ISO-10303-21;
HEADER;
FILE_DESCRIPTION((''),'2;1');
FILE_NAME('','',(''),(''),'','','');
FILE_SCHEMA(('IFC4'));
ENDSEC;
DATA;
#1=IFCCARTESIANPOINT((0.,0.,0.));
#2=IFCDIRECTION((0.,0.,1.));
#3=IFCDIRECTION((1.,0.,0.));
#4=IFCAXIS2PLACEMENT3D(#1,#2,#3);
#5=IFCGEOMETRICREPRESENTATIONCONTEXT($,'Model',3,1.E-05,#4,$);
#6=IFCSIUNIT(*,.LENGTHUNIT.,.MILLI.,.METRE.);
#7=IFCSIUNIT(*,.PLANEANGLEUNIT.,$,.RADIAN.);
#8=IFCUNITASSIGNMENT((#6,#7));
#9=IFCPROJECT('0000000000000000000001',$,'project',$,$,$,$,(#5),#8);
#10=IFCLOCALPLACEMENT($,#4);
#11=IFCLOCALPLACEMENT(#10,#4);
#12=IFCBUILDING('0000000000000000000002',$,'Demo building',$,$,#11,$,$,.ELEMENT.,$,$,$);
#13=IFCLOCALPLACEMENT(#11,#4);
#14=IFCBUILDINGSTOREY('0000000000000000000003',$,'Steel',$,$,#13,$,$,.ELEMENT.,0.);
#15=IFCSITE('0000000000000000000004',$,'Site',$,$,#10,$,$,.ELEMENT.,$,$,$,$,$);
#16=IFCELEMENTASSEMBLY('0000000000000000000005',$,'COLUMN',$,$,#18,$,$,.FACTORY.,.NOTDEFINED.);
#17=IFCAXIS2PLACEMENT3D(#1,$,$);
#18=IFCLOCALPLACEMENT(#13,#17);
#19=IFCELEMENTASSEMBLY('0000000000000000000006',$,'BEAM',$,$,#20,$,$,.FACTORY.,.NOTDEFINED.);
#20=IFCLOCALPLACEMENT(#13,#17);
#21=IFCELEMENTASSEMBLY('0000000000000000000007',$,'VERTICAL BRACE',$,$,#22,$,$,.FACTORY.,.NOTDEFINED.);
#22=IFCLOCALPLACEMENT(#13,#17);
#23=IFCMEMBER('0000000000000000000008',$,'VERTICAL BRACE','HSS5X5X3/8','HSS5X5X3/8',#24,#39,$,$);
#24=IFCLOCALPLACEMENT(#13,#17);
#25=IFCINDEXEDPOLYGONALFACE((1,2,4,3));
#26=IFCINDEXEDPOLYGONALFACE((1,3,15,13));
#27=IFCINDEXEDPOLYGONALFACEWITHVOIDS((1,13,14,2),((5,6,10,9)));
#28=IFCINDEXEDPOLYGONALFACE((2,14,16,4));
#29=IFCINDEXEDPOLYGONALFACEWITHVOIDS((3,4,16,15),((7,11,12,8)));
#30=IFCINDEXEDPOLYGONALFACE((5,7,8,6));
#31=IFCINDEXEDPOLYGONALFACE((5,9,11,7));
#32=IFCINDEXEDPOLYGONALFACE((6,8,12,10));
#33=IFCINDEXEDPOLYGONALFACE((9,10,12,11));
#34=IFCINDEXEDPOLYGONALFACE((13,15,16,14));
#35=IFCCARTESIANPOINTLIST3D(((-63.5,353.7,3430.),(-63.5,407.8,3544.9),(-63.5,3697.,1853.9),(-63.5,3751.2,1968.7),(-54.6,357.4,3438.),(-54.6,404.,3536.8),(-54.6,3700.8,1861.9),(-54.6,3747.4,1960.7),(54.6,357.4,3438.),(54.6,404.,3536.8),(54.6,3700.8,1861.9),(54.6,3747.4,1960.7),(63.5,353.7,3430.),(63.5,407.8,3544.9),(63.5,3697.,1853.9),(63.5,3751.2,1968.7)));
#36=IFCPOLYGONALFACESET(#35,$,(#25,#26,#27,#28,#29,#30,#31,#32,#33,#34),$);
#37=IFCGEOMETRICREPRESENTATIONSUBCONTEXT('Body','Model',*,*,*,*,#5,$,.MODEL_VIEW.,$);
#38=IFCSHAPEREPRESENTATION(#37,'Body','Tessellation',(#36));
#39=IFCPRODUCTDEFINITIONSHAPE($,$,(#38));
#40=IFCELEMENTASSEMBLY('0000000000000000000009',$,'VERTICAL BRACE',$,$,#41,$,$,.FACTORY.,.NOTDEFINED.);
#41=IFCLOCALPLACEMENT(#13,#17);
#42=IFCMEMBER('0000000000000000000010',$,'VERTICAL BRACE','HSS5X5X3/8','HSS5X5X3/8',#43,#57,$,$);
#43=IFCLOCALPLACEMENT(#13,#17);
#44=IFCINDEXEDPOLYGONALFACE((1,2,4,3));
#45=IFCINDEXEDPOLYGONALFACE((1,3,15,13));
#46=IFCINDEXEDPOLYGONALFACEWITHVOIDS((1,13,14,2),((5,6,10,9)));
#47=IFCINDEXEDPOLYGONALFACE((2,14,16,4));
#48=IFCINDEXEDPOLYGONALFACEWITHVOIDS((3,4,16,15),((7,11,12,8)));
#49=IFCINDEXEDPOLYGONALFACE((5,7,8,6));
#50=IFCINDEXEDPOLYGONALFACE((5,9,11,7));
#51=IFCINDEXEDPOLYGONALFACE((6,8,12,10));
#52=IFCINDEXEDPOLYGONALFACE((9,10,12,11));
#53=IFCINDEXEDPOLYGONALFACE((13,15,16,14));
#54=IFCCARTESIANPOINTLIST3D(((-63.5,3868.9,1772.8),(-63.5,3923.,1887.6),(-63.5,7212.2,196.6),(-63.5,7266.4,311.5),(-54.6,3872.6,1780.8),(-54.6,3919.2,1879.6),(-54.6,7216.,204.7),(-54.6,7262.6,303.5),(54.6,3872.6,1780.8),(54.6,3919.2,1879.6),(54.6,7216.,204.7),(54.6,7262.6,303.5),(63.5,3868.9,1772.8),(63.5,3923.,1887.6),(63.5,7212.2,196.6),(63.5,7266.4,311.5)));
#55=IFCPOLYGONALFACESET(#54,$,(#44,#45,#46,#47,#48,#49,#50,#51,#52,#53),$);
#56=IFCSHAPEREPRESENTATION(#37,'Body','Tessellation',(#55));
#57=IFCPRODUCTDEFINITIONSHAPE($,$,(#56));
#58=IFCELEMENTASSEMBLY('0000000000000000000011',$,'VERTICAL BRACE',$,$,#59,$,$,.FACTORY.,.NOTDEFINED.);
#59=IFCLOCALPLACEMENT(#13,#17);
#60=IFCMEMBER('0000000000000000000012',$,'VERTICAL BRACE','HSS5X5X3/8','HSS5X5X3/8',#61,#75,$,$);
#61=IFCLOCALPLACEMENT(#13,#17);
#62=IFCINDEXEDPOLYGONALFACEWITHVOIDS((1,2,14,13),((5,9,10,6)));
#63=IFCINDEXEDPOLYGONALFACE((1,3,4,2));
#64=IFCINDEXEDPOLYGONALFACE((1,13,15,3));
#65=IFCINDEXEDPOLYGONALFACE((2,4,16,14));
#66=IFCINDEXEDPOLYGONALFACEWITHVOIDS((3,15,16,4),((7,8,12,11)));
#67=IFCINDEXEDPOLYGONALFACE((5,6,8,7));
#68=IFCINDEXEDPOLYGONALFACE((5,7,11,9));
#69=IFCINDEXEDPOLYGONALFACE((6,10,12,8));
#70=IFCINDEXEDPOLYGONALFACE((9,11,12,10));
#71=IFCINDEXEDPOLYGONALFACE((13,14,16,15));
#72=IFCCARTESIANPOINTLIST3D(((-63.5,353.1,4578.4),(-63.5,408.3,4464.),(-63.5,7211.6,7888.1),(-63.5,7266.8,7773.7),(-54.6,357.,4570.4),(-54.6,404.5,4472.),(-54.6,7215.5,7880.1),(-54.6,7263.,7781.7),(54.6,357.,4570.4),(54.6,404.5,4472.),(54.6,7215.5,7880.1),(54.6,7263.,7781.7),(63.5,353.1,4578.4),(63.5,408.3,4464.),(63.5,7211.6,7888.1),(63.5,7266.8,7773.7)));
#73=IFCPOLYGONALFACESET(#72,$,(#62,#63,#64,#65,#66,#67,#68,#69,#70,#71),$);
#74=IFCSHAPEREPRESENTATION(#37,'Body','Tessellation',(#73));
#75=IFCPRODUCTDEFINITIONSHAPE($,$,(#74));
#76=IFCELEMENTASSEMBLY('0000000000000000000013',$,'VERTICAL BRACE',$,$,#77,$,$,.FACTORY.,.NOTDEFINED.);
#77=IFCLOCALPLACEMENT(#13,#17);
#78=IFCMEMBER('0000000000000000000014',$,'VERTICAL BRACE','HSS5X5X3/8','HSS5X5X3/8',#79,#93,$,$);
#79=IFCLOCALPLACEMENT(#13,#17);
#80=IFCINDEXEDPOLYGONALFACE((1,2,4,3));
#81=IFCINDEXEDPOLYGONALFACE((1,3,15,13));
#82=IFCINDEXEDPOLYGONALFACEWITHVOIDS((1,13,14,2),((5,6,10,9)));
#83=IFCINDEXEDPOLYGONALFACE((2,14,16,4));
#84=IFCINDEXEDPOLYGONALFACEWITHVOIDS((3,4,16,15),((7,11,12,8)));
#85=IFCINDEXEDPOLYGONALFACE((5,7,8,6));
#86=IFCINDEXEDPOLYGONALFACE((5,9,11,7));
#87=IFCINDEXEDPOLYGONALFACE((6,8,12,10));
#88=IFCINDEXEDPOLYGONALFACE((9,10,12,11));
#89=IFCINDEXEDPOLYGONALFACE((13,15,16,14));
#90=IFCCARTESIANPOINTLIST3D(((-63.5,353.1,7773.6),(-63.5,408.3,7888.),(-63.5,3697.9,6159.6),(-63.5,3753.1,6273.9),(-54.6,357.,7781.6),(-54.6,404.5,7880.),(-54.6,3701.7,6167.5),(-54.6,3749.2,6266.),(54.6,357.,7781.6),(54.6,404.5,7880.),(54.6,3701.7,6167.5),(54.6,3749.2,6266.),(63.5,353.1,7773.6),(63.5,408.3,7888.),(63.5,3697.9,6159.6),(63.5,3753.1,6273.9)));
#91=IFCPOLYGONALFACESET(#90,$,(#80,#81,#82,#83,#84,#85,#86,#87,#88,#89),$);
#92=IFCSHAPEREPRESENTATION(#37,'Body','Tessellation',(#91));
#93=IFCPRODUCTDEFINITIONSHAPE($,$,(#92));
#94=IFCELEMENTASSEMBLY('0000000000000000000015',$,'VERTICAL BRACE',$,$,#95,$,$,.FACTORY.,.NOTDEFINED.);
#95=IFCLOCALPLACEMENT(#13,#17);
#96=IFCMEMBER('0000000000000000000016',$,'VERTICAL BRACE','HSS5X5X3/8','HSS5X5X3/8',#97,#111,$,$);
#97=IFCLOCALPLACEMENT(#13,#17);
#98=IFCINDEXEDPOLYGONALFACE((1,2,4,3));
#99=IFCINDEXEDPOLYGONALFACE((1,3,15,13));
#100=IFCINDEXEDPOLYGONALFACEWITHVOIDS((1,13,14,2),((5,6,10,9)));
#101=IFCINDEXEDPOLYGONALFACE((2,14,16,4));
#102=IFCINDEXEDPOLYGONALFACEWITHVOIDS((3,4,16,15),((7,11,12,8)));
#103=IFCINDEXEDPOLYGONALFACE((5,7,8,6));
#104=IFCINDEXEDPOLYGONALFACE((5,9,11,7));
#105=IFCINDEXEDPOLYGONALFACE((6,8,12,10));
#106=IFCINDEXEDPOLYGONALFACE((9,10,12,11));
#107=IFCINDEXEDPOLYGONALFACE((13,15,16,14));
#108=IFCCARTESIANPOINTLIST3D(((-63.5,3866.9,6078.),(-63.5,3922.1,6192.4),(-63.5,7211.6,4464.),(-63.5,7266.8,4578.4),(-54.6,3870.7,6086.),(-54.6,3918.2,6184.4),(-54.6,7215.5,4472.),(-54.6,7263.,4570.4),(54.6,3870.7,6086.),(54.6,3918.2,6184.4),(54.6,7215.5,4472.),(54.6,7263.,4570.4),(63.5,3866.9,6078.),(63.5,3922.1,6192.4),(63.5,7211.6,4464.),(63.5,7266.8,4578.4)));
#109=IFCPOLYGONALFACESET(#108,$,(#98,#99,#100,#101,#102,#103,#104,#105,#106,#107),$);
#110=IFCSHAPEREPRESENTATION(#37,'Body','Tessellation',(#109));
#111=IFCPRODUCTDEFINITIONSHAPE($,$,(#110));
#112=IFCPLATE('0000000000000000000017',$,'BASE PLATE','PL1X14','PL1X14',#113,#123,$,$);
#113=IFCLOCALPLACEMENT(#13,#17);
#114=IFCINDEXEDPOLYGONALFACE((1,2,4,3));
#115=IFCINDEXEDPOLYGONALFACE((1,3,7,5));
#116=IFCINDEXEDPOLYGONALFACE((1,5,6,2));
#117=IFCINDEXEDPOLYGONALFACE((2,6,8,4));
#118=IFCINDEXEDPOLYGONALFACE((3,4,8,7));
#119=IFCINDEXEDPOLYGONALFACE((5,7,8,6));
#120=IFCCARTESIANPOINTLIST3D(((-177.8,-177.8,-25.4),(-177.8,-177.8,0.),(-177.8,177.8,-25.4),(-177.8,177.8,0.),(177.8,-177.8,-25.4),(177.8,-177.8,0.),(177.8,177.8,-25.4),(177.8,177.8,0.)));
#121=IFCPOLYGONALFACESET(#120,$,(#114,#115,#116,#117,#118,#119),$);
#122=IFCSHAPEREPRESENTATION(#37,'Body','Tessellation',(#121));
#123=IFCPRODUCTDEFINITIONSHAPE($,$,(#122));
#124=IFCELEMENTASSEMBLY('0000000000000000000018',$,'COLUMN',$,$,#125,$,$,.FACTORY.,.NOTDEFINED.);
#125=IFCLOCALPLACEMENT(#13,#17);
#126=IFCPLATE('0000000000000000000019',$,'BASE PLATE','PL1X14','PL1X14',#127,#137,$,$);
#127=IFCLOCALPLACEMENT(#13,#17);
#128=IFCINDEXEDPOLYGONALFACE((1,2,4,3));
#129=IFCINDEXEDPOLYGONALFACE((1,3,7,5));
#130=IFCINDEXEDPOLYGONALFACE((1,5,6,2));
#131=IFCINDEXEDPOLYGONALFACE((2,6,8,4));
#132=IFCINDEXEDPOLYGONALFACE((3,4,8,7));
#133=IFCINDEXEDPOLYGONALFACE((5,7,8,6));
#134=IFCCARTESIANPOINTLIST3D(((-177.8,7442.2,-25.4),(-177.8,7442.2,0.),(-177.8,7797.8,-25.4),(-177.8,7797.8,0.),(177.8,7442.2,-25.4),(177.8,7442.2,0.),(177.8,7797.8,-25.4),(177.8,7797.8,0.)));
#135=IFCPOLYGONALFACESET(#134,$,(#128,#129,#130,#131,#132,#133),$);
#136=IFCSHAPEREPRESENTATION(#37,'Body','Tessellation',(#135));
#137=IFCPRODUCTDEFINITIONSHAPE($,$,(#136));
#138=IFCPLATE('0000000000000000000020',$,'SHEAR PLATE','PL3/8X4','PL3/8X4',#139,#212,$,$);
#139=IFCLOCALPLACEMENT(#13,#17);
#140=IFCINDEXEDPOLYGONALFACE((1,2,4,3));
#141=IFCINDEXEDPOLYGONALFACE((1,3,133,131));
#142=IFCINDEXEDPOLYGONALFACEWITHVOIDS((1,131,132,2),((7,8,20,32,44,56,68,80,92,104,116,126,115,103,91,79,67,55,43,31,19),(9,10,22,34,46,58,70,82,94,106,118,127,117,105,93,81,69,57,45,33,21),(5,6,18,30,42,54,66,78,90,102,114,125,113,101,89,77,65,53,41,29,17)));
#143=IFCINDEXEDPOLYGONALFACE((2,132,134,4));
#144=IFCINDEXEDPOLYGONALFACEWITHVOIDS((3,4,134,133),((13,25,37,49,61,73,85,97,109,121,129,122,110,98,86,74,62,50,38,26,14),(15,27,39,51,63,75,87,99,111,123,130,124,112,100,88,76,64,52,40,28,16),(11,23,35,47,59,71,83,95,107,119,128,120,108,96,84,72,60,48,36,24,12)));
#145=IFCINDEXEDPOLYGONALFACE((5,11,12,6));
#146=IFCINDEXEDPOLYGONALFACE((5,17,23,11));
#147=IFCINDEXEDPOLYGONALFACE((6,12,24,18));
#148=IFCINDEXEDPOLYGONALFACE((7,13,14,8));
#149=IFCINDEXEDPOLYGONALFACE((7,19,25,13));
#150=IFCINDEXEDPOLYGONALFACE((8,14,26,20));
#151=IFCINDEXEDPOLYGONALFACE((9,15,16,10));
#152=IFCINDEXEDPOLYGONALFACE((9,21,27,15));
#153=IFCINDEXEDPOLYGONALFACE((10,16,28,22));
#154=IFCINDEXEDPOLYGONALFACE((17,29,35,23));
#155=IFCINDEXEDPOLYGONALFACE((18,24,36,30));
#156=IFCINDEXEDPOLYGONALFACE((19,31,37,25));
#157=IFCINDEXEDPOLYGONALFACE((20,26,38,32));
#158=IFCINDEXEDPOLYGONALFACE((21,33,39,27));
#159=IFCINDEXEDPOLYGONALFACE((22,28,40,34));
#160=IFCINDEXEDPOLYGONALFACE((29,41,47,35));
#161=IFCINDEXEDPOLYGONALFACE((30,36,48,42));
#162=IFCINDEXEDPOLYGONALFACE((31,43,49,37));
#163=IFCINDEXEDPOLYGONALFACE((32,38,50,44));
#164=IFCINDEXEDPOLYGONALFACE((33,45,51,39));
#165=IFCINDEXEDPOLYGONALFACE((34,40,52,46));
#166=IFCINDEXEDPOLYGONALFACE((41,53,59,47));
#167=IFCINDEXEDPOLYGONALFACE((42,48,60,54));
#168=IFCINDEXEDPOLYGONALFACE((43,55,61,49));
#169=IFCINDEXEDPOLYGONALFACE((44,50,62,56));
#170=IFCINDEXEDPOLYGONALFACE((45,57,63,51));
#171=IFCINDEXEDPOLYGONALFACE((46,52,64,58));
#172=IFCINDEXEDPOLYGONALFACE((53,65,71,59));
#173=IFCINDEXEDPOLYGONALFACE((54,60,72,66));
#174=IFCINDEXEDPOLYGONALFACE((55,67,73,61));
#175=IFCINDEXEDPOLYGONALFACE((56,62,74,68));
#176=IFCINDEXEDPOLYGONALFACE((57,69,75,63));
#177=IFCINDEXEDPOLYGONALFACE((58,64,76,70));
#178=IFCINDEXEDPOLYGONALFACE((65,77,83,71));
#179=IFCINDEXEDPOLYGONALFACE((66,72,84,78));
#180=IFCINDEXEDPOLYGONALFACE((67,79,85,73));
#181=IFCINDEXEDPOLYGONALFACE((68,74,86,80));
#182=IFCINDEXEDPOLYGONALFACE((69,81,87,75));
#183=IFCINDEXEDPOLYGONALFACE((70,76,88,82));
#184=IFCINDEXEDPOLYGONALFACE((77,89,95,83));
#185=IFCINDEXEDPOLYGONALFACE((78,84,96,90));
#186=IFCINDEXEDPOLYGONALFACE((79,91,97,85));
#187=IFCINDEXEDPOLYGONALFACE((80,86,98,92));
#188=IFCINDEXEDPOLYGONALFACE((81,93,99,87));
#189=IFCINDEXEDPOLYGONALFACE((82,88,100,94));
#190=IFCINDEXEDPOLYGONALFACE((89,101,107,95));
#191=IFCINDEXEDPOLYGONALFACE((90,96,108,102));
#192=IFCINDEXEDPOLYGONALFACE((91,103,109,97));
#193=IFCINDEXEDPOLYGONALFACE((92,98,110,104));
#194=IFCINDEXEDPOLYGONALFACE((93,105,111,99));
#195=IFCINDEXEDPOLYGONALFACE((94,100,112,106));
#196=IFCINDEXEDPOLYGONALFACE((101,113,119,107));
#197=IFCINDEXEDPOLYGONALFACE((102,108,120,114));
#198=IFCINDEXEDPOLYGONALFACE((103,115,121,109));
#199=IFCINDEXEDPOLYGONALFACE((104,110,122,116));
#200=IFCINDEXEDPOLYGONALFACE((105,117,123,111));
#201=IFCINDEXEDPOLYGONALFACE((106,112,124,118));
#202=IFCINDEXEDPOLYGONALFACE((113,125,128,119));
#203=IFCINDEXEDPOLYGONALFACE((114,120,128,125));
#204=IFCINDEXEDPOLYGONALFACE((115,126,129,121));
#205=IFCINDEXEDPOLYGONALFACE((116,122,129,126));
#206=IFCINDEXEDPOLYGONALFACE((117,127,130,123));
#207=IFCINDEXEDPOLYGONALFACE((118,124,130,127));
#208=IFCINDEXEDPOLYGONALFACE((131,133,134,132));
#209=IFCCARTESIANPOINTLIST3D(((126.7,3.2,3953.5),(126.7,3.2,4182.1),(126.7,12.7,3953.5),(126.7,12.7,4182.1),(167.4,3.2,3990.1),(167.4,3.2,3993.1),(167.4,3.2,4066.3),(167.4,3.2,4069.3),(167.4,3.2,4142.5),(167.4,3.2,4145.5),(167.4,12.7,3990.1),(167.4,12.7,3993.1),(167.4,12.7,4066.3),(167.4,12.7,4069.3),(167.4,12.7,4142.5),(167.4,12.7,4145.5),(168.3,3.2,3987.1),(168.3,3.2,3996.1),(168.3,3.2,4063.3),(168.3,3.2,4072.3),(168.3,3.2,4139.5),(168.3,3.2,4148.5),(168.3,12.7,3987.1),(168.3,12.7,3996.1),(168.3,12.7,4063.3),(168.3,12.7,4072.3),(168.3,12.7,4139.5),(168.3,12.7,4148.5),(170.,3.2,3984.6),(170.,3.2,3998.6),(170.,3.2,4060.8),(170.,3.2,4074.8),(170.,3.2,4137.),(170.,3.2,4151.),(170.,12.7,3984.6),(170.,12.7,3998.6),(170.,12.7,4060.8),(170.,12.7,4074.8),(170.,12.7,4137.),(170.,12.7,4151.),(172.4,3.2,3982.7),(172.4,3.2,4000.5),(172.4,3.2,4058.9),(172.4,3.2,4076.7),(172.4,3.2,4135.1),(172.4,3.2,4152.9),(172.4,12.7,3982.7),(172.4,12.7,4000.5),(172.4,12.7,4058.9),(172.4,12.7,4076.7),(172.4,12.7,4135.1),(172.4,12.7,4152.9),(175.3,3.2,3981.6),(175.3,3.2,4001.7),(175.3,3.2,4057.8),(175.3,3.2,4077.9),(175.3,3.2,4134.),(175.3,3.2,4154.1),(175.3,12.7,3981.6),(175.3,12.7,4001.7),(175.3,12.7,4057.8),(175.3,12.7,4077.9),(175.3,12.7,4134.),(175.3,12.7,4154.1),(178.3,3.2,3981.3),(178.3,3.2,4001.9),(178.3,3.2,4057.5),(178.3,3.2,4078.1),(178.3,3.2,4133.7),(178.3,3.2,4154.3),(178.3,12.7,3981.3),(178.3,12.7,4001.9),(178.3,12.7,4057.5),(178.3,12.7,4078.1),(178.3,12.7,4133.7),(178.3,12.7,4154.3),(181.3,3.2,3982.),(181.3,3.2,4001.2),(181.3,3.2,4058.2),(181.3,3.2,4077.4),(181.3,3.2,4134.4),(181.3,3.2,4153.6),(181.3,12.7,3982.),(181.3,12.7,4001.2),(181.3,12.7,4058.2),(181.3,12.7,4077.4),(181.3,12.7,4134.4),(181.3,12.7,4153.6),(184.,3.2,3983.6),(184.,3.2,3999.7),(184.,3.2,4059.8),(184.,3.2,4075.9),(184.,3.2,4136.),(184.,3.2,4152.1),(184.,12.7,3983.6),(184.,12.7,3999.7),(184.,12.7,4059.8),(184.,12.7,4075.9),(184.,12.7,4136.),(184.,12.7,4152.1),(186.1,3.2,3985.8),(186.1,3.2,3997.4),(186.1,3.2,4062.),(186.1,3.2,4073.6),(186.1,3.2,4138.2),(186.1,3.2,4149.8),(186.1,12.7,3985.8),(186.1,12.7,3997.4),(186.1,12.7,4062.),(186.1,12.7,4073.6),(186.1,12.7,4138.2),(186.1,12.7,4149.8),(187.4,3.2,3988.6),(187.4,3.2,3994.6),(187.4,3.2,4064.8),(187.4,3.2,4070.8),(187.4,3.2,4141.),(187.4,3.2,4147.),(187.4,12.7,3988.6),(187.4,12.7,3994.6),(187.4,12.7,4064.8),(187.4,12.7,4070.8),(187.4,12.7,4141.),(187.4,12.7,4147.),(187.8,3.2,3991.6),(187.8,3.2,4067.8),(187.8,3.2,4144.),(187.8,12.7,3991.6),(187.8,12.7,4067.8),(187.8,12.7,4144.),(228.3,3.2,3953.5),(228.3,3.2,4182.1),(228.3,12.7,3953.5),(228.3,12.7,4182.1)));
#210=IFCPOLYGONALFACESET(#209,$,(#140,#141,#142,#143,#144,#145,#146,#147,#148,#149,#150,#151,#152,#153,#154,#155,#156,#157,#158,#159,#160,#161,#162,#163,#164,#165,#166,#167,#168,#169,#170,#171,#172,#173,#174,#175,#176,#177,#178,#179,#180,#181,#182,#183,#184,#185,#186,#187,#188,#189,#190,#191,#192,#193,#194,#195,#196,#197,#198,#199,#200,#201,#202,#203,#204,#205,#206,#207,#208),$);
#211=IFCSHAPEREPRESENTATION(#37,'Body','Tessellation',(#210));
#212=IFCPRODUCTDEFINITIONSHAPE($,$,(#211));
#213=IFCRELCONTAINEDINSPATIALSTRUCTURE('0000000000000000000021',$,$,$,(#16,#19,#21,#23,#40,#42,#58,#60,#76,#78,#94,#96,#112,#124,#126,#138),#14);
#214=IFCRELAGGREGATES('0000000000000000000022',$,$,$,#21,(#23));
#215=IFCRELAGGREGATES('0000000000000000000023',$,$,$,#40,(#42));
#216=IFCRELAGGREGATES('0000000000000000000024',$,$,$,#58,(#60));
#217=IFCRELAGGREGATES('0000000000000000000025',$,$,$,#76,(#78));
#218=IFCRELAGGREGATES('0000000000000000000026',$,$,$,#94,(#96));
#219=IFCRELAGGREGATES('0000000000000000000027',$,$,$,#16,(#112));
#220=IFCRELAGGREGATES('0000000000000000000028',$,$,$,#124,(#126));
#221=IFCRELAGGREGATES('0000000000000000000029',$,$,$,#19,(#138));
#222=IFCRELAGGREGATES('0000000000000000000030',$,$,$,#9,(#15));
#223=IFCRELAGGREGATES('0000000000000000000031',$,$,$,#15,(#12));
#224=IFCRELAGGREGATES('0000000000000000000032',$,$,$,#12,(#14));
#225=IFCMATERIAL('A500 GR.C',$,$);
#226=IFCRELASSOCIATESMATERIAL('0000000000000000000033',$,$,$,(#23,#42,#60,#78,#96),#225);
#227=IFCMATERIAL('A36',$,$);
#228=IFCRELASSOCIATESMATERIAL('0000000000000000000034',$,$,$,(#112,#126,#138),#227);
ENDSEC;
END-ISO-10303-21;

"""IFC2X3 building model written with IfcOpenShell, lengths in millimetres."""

from ifc_helpers import new_model, si_unit, frame, frame_2d, origin, origin_with_axes, origin_2d, place, context, subcontext, project, spatial, rectangle, hollow_rectangle, circle, extrude, boolean, material, element, aggregate, save


model = new_model("IFC2X3")

# Units and contexts
model_context = context("Model", 3, precision=1e-05, world=origin_with_axes())
body_context = subcontext(model_context, "Body", "Model", "MODEL_VIEW")
ifc_project = project(units=[si_unit("LENGTHUNIT", "METRE", prefix="MILLI"), si_unit("PLANEANGLEUNIT", "RADIAN")], contexts=[model_context])

# Site, building, storey
site_placement = place(None, origin_with_axes())
site = spatial("IfcSite", under=ifc_project, at=site_placement, Name="Site", CompositionType="ELEMENT")
building_placement = place(site_placement, origin_with_axes())
building = spatial("IfcBuilding", under=site, at=building_placement, Name="Demo building", CompositionType="ELEMENT")
placement = place(building_placement, origin_with_axes())
storey = spatial("IfcBuildingStorey", under=building, at=placement, Name="Steel", CompositionType="ELEMENT", Elevation=0.0)

# Element assembly
assembly_1 = element("IfcElementAssembly", 1, at=placement, inside=storey, Name="COLUMN", AssemblyPlace="FACTORY", PredefinedType="NOTDEFINED")

# Element assembly
assembly_2 = element("IfcElementAssembly", 2, at=placement, inside=storey, Name="BEAM", AssemblyPlace="FACTORY", PredefinedType="NOTDEFINED")

# Element assemblies, members
ifc_material_1 = material(Name="A500 GR.C")
assembly_3 = element("IfcElementAssembly", 3, at=placement, inside=storey, Name="VERTICAL BRACE", AssemblyPlace="FACTORY", PredefinedType="NOTDEFINED")
member_1_placement = place(placement, frame((0.0, 380.7, 3487.4), z_axis=(0.0, 0.9045, -0.4264), x_axis=(-1.0, 0.0, 0.0)))
member_1 = element("IfcMember", 4, at=member_1_placement, inside=storey, material=ifc_material_1, Name="VERTICAL BRACE", Description="HSS5X5X3/8", ObjectType="HSS5X5X3/8", context=body_context, shape_type="SweptSolid", body=[
    extrude(hollow_rectangle(XDim=127.0, YDim=127.0, WallThickness=8.9, at=origin_2d()), origin(), (0.0, 0.0, 1.0), 3696.2),
])
aggregate(assembly_3, [member_1])
assembly_4 = element("IfcElementAssembly", 5, at=placement, inside=storey, Name="VERTICAL BRACE", AssemblyPlace="FACTORY", PredefinedType="NOTDEFINED")
member_2_placement = place(placement, frame((0.0, 3895.9, 1830.2), z_axis=(0.0, 0.9045, -0.4264), x_axis=(-1.0, 0.0, 0.0)))
member_2 = element("IfcMember", 6, at=member_2_placement, inside=storey, material=ifc_material_1, Name="VERTICAL BRACE", Description="HSS5X5X3/8", ObjectType="HSS5X5X3/8", context=body_context, shape_type="SweptSolid", body=[
    extrude(hollow_rectangle(XDim=127.0, YDim=127.0, WallThickness=8.9, at=origin_2d()), origin(), (0.0, 0.0, 1.0), 3696.2),
])
aggregate(assembly_4, [member_2])
assembly_5 = element("IfcElementAssembly", 7, at=placement, inside=storey, Name="VERTICAL BRACE", AssemblyPlace="FACTORY", PredefinedType="NOTDEFINED")
member_3_placement = place(placement, frame((0.0, 380.7, 4521.2), z_axis=(0.0, 0.9006, 0.4346), x_axis=(-1.0, 0.0, 0.0)))
member_3 = element("IfcMember", 8, at=member_3_placement, inside=storey, material=ifc_material_1, Name="VERTICAL BRACE", Description="HSS5X5X3/8", ObjectType="HSS5X5X3/8", context=body_context, shape_type="SweptSolid", body=[
    extrude(hollow_rectangle(XDim=127.0, YDim=127.0, WallThickness=8.9, at=origin_2d()), origin(), (0.0, 0.0, 1.0), 7615.3),
])
aggregate(assembly_5, [member_3])
assembly_6 = element("IfcElementAssembly", 9, at=placement, inside=storey, Name="VERTICAL BRACE", AssemblyPlace="FACTORY", PredefinedType="NOTDEFINED")
member_4_placement = place(placement, frame((0.0, 380.7, 7830.8), z_axis=(0.0, 0.9006, -0.4346), x_axis=(-1.0, 0.0, 0.0)))
member_4 = element("IfcMember", 10, at=member_4_placement, inside=storey, material=ifc_material_1, Name="VERTICAL BRACE", Description="HSS5X5X3/8", ObjectType="HSS5X5X3/8", context=body_context, shape_type="SweptSolid", body=[
    extrude(hollow_rectangle(XDim=127.0, YDim=127.0, WallThickness=8.9, at=origin_2d()), origin(), (0.0, 0.0, 1.0), 3713.8),
])
aggregate(assembly_6, [member_4])
assembly_7 = element("IfcElementAssembly", 11, at=placement, inside=storey, Name="VERTICAL BRACE", AssemblyPlace="FACTORY", PredefinedType="NOTDEFINED")
member_5_placement = place(placement, frame((0.0, 3894.5, 6135.2), z_axis=(0.0, 0.9006, -0.4346), x_axis=(-1.0, 0.0, 0.0)))
member_5 = element("IfcMember", 12, at=member_5_placement, inside=storey, material=ifc_material_1, Name="VERTICAL BRACE", Description="HSS5X5X3/8", ObjectType="HSS5X5X3/8", context=body_context, shape_type="SweptSolid", body=[
    extrude(hollow_rectangle(XDim=127.0, YDim=127.0, WallThickness=8.9, at=origin_2d()), origin(), (0.0, 0.0, 1.0), 3713.8),
])
aggregate(assembly_7, [member_5])

# Plate
ifc_material_2 = material(Name="A36")
plate_1_placement = place(placement, frame((-177.8, -177.8, -25.4), z_axis=(0.0, 0.0, 1.0), x_axis=(1.0, 0.0, 0.0)))
plate_1 = element("IfcPlate", 13, at=plate_1_placement, inside=storey, material=ifc_material_2, Name="BASE PLATE", Description="PL1X14", ObjectType="PL1X14", context=body_context, shape_type="SweptSolid", body=[
    extrude(rectangle(XDim=355.6, YDim=355.6, at=frame_2d((177.8, 177.8))), origin(), (0.0, 0.0, 1.0), 25.4),
])
aggregate(assembly_1, [plate_1])

# Element assembly, plate
assembly_8 = element("IfcElementAssembly", 14, at=placement, inside=storey, Name="COLUMN", AssemblyPlace="FACTORY", PredefinedType="NOTDEFINED")
plate_2_placement = place(placement, frame((-177.8, 7442.2, -25.4), z_axis=(0.0, 0.0, 1.0), x_axis=(1.0, 0.0, 0.0)))
plate_2 = element("IfcPlate", 15, at=plate_2_placement, inside=storey, material=ifc_material_2, Name="BASE PLATE", Description="PL1X14", ObjectType="PL1X14", context=body_context, shape_type="SweptSolid", body=[
    extrude(rectangle(XDim=355.6, YDim=355.6, at=frame_2d((177.8, 177.8))), origin(), (0.0, 0.0, 1.0), 25.4),
])
aggregate(assembly_8, [plate_2])

# Plate
plate_3_placement = place(placement, frame((126.7, 12.7, 3953.5), z_axis=(0.0, -1.0, 0.0), x_axis=(1.0, 0.0, 0.0)))
plate_3 = element("IfcPlate", 16, at=plate_3_placement, inside=storey, material=ifc_material_2, Name="SHEAR PLATE", Description="PL3/8X4", ObjectType="PL3/8X4", context=body_context, shape_type="CSG", body=[
    boolean("DIFFERENCE", boolean("DIFFERENCE", boolean("DIFFERENCE", extrude(rectangle(XDim=101.6, YDim=228.6, at=frame_2d((50.8, 114.3))), origin(), (0.0, 0.0, 1.0), 9.5), extrude(circle(Radius=10.3, at=frame_2d((50.8, 38.1))), frame((0.0, 0.0, -5.0)), (0.0, 0.0, 1.0), 19.5)), extrude(circle(Radius=10.3, at=frame_2d((50.8, 114.3))), frame((0.0, 0.0, -5.0)), (0.0, 0.0, 1.0), 19.5)), extrude(circle(Radius=10.3, at=frame_2d((50.8, 190.5))), frame((0.0, 0.0, -5.0)), (0.0, 0.0, 1.0), 19.5)),
])
aggregate(assembly_2, [plate_3])

save(model, "model.ifc")
